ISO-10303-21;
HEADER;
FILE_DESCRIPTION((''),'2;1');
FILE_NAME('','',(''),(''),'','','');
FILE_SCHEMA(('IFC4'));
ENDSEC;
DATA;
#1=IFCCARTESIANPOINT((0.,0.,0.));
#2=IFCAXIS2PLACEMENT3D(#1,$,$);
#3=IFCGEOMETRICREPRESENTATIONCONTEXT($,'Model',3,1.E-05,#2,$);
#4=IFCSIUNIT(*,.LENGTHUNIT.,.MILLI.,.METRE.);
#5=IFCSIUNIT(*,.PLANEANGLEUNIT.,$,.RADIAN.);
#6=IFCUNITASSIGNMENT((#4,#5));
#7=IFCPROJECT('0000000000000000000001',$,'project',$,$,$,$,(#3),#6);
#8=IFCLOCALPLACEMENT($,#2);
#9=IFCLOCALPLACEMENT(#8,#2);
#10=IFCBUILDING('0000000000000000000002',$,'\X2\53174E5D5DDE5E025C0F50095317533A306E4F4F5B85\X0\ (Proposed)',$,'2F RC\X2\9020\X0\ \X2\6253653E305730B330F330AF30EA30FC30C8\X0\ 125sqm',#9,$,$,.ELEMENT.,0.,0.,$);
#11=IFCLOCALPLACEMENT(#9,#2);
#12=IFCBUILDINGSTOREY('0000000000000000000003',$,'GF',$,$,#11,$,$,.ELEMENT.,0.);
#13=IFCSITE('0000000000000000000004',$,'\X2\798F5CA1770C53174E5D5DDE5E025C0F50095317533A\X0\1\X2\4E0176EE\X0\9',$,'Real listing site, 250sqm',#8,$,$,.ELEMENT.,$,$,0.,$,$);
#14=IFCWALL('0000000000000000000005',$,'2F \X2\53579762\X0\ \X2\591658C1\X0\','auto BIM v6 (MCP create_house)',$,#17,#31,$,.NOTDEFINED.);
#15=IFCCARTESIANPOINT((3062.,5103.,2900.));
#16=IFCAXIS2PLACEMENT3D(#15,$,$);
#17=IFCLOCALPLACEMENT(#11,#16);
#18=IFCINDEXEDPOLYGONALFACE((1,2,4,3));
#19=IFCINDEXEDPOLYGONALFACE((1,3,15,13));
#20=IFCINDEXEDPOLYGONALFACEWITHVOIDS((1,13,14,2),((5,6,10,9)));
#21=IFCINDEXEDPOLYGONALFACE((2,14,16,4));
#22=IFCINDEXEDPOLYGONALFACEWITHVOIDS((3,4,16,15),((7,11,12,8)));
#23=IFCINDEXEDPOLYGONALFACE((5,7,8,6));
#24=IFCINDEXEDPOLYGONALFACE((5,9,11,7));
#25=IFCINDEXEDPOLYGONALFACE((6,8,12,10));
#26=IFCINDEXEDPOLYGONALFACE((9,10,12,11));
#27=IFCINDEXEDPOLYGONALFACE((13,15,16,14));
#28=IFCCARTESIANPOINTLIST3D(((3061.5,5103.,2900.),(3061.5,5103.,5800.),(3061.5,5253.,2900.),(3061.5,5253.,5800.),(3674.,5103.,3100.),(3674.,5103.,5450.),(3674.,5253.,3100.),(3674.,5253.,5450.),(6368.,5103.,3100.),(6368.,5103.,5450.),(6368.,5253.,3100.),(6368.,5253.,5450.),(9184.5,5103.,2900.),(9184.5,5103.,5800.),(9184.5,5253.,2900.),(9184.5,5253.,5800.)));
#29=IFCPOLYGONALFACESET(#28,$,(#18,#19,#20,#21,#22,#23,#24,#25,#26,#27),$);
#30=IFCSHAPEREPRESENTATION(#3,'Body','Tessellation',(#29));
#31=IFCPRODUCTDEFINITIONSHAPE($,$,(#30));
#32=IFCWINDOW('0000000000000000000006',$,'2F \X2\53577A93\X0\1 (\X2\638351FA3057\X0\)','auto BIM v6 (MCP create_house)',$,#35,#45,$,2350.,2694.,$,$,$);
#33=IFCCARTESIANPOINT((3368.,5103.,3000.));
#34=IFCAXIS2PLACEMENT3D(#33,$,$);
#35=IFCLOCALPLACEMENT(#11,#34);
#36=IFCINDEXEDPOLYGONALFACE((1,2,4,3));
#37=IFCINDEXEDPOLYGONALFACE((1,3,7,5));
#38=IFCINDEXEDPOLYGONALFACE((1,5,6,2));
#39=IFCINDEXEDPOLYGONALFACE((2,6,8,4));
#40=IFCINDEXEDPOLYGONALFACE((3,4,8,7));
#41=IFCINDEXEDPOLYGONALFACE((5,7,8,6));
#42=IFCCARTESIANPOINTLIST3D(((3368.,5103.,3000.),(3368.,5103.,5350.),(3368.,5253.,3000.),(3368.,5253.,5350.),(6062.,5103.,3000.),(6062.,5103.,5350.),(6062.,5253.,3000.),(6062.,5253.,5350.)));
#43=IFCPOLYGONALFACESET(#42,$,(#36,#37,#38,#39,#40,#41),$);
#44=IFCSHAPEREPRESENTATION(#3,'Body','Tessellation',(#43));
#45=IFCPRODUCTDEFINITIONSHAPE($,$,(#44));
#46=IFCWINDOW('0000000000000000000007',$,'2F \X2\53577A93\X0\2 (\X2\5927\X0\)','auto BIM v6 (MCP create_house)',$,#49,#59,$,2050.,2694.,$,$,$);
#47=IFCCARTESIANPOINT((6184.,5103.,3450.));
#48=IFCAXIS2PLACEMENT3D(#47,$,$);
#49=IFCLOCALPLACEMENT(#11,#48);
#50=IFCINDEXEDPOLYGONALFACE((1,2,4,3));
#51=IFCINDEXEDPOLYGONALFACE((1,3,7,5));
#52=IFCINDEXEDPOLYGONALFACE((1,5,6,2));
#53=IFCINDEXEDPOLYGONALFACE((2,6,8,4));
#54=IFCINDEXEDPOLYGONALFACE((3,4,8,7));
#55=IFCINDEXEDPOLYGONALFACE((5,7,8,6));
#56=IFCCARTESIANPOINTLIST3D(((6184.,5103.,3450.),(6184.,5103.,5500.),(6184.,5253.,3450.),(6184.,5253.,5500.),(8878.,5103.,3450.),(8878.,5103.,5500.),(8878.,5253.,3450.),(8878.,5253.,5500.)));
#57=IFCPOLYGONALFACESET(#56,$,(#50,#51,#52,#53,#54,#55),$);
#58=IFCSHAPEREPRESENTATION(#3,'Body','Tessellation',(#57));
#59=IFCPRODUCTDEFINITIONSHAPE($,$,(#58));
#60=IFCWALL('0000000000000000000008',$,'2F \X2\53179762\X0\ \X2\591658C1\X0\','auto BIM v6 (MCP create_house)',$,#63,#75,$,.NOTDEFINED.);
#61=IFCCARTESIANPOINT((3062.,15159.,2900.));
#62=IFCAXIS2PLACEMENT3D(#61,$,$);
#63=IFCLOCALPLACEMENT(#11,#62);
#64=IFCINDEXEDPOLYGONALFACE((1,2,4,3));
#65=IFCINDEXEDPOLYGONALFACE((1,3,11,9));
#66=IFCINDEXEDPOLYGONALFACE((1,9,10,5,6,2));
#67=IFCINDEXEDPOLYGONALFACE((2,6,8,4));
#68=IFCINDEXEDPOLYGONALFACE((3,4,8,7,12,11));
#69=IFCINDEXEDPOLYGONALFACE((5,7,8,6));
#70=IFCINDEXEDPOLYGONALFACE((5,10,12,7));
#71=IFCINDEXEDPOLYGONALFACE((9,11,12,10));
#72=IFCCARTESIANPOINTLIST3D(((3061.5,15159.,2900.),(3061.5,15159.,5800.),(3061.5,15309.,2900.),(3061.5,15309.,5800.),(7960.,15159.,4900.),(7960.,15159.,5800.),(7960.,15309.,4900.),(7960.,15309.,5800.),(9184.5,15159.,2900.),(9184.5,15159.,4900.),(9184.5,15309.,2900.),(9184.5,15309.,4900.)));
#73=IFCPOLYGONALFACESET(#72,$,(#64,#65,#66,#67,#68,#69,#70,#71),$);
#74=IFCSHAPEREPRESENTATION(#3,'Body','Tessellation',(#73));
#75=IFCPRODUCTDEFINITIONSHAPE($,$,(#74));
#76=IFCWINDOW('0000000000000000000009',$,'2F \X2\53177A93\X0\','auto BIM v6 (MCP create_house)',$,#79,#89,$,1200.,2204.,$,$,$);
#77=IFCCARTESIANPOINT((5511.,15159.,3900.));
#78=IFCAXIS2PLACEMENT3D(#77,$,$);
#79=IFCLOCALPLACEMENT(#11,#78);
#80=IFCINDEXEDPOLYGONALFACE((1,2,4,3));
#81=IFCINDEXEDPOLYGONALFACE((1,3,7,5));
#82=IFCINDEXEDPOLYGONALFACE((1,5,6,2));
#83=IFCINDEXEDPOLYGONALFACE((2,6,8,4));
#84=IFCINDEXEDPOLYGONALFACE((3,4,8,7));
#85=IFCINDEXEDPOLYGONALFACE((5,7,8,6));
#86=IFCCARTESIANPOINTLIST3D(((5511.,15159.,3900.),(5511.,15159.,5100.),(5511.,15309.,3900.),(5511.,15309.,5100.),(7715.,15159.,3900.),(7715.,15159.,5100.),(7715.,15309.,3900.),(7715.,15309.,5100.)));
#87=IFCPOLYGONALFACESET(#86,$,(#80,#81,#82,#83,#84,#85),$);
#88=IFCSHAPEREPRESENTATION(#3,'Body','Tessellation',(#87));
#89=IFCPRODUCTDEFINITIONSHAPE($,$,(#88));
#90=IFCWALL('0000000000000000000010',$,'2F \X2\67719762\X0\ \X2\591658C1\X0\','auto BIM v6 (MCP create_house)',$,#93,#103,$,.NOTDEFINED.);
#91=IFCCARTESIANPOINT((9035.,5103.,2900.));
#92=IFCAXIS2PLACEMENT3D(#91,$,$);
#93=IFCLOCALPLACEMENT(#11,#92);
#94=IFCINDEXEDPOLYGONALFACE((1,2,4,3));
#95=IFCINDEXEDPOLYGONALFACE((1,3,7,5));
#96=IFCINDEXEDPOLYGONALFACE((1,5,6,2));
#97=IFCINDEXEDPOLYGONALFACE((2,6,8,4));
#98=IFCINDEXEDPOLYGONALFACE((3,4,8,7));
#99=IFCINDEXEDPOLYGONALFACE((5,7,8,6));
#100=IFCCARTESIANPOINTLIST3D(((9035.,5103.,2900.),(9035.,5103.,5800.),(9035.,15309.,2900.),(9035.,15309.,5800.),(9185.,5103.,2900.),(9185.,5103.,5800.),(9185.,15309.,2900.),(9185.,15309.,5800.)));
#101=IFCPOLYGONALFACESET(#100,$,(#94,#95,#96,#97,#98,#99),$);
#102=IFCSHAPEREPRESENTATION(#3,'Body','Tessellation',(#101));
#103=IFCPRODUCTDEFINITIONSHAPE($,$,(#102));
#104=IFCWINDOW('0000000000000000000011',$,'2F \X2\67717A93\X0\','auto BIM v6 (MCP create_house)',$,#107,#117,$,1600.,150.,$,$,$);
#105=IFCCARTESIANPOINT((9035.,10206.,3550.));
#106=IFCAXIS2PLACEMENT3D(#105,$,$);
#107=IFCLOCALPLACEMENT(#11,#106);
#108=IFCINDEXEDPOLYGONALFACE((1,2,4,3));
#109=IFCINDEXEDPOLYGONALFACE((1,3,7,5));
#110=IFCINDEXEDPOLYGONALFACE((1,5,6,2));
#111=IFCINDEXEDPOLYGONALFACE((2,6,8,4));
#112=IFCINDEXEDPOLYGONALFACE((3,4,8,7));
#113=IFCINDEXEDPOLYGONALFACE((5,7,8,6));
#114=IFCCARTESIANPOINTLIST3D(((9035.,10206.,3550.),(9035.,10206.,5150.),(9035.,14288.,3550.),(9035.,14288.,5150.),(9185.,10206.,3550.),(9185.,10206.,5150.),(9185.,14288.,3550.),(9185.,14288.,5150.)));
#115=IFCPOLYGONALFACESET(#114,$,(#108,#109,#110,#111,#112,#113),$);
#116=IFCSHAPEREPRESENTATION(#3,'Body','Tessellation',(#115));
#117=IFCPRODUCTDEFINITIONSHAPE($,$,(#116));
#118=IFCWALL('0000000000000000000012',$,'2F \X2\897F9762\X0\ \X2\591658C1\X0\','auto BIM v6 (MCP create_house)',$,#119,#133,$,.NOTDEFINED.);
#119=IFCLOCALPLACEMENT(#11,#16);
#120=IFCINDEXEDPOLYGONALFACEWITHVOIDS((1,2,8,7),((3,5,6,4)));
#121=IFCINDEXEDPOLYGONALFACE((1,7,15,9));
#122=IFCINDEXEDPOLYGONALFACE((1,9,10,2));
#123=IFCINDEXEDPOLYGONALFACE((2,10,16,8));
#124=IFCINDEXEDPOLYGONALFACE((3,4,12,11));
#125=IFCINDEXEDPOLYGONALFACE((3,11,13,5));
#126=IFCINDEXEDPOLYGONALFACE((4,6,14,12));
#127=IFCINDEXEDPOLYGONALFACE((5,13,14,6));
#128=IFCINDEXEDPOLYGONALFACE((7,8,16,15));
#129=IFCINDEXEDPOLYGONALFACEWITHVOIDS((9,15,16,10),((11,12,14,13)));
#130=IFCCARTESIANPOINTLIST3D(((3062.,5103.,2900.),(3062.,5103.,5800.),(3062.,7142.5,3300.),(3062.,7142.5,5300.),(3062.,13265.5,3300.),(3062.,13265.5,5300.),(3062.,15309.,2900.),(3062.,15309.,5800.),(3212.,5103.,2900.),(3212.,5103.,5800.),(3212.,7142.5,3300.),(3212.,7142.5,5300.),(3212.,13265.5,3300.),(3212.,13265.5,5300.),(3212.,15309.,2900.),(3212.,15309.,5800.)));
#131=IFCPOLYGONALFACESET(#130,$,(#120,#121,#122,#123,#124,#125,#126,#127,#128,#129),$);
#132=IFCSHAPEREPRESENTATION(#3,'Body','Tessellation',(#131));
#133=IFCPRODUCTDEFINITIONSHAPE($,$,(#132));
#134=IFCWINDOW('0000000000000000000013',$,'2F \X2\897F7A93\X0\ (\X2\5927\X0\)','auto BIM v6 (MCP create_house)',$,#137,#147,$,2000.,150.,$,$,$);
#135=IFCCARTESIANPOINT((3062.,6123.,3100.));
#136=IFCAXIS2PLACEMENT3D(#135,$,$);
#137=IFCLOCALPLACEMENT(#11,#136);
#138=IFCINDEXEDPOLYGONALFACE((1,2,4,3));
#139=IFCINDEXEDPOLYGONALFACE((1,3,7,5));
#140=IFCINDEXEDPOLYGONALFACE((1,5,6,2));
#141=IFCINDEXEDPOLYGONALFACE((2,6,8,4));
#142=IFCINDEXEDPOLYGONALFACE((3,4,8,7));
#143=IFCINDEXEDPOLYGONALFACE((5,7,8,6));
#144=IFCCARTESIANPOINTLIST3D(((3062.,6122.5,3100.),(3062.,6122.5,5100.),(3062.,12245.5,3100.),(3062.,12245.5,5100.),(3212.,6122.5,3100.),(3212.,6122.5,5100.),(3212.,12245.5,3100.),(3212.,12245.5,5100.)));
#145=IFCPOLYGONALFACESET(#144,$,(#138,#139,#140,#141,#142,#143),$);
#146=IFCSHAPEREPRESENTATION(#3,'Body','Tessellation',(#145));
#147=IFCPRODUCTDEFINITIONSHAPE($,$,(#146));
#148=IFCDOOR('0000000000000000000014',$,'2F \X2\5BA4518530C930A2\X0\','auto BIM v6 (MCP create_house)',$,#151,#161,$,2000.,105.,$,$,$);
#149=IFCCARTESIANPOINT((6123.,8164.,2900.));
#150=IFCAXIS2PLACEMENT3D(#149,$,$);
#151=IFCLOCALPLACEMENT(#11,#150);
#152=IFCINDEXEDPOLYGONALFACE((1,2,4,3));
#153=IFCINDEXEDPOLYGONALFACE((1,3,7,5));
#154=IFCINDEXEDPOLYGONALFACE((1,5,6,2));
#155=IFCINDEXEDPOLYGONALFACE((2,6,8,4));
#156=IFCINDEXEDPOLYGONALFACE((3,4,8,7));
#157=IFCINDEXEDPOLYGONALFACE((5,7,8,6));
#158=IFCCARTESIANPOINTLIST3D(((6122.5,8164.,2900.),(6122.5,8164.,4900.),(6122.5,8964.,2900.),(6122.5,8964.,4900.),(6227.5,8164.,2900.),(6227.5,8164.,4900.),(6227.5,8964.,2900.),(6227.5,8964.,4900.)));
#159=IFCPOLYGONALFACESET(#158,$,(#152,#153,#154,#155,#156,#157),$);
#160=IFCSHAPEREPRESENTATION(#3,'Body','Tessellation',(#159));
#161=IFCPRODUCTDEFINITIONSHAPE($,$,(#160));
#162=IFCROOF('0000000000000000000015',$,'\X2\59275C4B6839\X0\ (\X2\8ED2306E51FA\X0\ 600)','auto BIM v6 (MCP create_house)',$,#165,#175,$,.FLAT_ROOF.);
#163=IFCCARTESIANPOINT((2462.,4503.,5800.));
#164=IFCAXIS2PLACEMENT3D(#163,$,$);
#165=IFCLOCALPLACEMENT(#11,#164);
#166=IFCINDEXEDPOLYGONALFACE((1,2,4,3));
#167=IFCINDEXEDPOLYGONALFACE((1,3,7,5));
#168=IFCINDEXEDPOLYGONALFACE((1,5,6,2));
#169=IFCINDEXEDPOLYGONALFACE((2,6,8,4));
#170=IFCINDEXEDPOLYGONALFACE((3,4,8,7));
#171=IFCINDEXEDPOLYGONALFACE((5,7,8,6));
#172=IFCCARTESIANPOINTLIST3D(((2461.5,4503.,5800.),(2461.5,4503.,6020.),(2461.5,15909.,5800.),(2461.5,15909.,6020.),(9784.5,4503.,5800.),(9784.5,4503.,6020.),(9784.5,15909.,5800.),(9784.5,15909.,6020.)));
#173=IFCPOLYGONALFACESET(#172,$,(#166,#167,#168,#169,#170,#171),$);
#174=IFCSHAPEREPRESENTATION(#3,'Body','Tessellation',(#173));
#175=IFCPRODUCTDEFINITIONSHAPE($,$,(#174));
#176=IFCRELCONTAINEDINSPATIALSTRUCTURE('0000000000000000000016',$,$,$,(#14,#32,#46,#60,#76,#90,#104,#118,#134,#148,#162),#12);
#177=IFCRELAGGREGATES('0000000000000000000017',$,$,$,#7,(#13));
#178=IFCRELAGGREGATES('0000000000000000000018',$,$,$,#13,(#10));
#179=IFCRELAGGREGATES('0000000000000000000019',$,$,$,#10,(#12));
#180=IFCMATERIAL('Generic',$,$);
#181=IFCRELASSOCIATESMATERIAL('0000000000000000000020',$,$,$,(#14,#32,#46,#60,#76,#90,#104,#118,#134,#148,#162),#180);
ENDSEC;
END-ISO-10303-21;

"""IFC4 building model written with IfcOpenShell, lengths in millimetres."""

from ifc_helpers import new_model, si_unit, frame, frame_2d, origin, place, context, project, spatial, rectangle, extrude, material, element, fill, save


model = new_model("IFC4")

# Units and contexts
model_context = context("Model", 3, precision=1e-05, world=origin())
ifc_project = project(units=[si_unit("LENGTHUNIT", "METRE", prefix="MILLI"), si_unit("PLANEANGLEUNIT", "RADIAN")], contexts=[model_context])

# Site, building, storey
site_placement = place(None, origin())
site = spatial("IfcSite", under=ifc_project, at=site_placement, Name="福岡県北九州市小倉北区1丁目9", ObjectType="Real listing site, 250sqm", CompositionType="ELEMENT", RefElevation=0.0)
building_placement = place(site_placement, origin())
building = spatial("IfcBuilding", under=site, at=building_placement, Name="北九州市小倉北区の住宅 (Proposed)", ObjectType="2F RC造 打放しコンクリート 125sqm", CompositionType="ELEMENT", ElevationOfRefHeight=0.0, ElevationOfTerrain=0.0)
storey_placement = place(building_placement, origin())
storey = spatial("IfcBuildingStorey", under=building, at=storey_placement, Name="GF", CompositionType="ELEMENT", Elevation=0.0)

# Shared definitions
ifc_material = material(Name="Generic")

# Wall, openings, windows
wall_1_placement = place(storey_placement, frame((3062.0, 5103.0, 2900.0)))
wall_1 = element("IfcWall", 1, at=wall_1_placement, inside=storey, material=ifc_material, Name="2F 南面 外壁", Description="auto BIM v6 (MCP create_house)", PredefinedType="NOTDEFINED", context=model_context, shape_type="SweptSolid", body=[
    extrude(rectangle(XDim=6123.0, YDim=150.0, at=frame_2d((3061.0, 75.0))), frame((3062.0, 5103.0, 2900.0)), (0.0, 0.0, 1.0), 2900.0),
])
opening_1_placement = place(storey_placement, frame((3368.0, 5103.0, 3000.0)))
opening_1 = element("IfcOpeningElement", 2, at=opening_1_placement, cuts=wall_1, PredefinedType="NOTDEFINED", context=model_context, shape_type="SweptSolid", body=[
    extrude(rectangle(XDim=2694.0, YDim=150.0, at=frame_2d((1347.0, 75.0))), frame((3368.0, 5103.0, 3000.0)), (0.0, 0.0, 1.0), 2350.0),
])
opening_2_placement = place(storey_placement, frame((6184.0, 5103.0, 3450.0)))
opening_2 = element("IfcOpeningElement", 3, at=opening_2_placement, cuts=wall_1, PredefinedType="NOTDEFINED", context=model_context, shape_type="SweptSolid", body=[
    extrude(rectangle(XDim=2694.0, YDim=150.0, at=frame_2d((1347.0, 75.0))), frame((6184.0, 5103.0, 3450.0)), (0.0, 0.0, 1.0), 2050.0),
])
window_1_placement = place(storey_placement, frame((3368.0, 5103.0, 3000.0)))
window_1 = element("IfcWindow", 4, at=window_1_placement, inside=storey, material=ifc_material, Name="2F 南窓1 (掃出し)", Description="auto BIM v6 (MCP create_house)", OverallHeight=2350.0, OverallWidth=2694.0, context=model_context, shape_type="SweptSolid", body=[
    extrude(rectangle(XDim=2694.0, YDim=150.0, at=frame_2d((1347.0, 75.0))), frame((3368.0, 5103.0, 3000.0)), (0.0, 0.0, 1.0), 2350.0),
])
fill(opening_1, window_1)
window_2_placement = place(storey_placement, frame((6184.0, 5103.0, 3450.0)))
window_2 = element("IfcWindow", 5, at=window_2_placement, inside=storey, material=ifc_material, Name="2F 南窓2 (大)", Description="auto BIM v6 (MCP create_house)", OverallHeight=2050.0, OverallWidth=2694.0, context=model_context, shape_type="SweptSolid", body=[
    extrude(rectangle(XDim=2694.0, YDim=150.0, at=frame_2d((1347.0, 75.0))), frame((6184.0, 5103.0, 3450.0)), (0.0, 0.0, 1.0), 2050.0),
])
fill(opening_2, window_2)

# Walls, openings, windows
wall_2_placement = place(storey_placement, frame((3062.0, 15159.0, 2900.0)))
wall_2 = element("IfcWall", 6, at=wall_2_placement, inside=storey, material=ifc_material, Name="2F 北面 外壁", Description="auto BIM v6 (MCP create_house)", PredefinedType="NOTDEFINED", context=model_context, shape_type="SweptSolid", body=[
    extrude(rectangle(XDim=6123.0, YDim=150.0, at=frame_2d((3061.0, 75.0))), frame((3062.0, 15159.0, 2900.0)), (0.0, 0.0, 1.0), 2900.0),
])
opening_3_placement = place(storey_placement, frame((5511.0, 15159.0, 3900.0)))
opening_3 = element("IfcOpeningElement", 7, at=opening_3_placement, cuts=wall_2, PredefinedType="NOTDEFINED", context=model_context, shape_type="SweptSolid", body=[
    extrude(rectangle(XDim=2204.0, YDim=150.0, at=frame_2d((1102.0, 75.0))), frame((5511.0, 15159.0, 3900.0)), (0.0, 0.0, 1.0), 1200.0),
])
window_3_placement = place(storey_placement, frame((5511.0, 15159.0, 3900.0)))
window_3 = element("IfcWindow", 8, at=window_3_placement, inside=storey, material=ifc_material, Name="2F 北窓", Description="auto BIM v6 (MCP create_house)", OverallHeight=1200.0, OverallWidth=2204.0, context=model_context, shape_type="SweptSolid", body=[
    extrude(rectangle(XDim=2204.0, YDim=150.0, at=frame_2d((1102.0, 75.0))), frame((5511.0, 15159.0, 3900.0)), (0.0, 0.0, 1.0), 1200.0),
])
fill(opening_3, window_3)
wall_3_placement = place(storey_placement, frame((9035.0, 5103.0, 2900.0)))
wall_3 = element("IfcWall", 9, at=wall_3_placement, inside=storey, material=ifc_material, Name="2F 東面 外壁", Description="auto BIM v6 (MCP create_house)", PredefinedType="NOTDEFINED", context=model_context, shape_type="SweptSolid", body=[
    extrude(rectangle(XDim=150.0, YDim=10206.0, at=frame_2d((75.0, 5103.0))), frame((9035.0, 5103.0, 2900.0)), (0.0, 0.0, 1.0), 2900.0),
])
opening_4_placement = place(storey_placement, frame((9035.0, 10206.0, 3550.0)))
opening_4 = element("IfcOpeningElement", 10, at=opening_4_placement, cuts=wall_3, PredefinedType="NOTDEFINED", context=model_context, shape_type="SweptSolid", body=[
    extrude(rectangle(XDim=150.0, YDim=4082.0, at=frame_2d((75.0, 2041.0))), frame((9035.0, 10206.0, 3550.0)), (0.0, 0.0, 1.0), 1600.0),
])
window_4_placement = place(storey_placement, frame((9035.0, 10206.0, 3550.0)))
window_4 = element("IfcWindow", 11, at=window_4_placement, inside=storey, material=ifc_material, Name="2F 東窓", Description="auto BIM v6 (MCP create_house)", OverallHeight=1600.0, OverallWidth=150.0, context=model_context, shape_type="SweptSolid", body=[
    extrude(rectangle(XDim=150.0, YDim=4082.0, at=frame_2d((75.0, 2041.0))), frame((9035.0, 10206.0, 3550.0)), (0.0, 0.0, 1.0), 1600.0),
])
fill(opening_4, window_4)
wall_4_placement = place(storey_placement, frame((3062.0, 5103.0, 2900.0)))
wall_4 = element("IfcWall", 12, at=wall_4_placement, inside=storey, material=ifc_material, Name="2F 西面 外壁", Description="auto BIM v6 (MCP create_house)", PredefinedType="NOTDEFINED", context=model_context, shape_type="SweptSolid", body=[
    extrude(rectangle(XDim=150.0, YDim=10206.0, at=frame_2d((75.0, 5103.0))), frame((3062.0, 5103.0, 2900.0)), (0.0, 0.0, 1.0), 2900.0),
])
opening_5_placement = place(storey_placement, frame((3062.0, 6123.0, 3100.0)))
opening_5 = element("IfcOpeningElement", 13, at=opening_5_placement, cuts=wall_4, PredefinedType="NOTDEFINED", context=model_context, shape_type="SweptSolid", body=[
    extrude(rectangle(XDim=150.0, YDim=6123.0, at=frame_2d((75.0, 3061.0))), frame((3062.0, 6123.0, 3100.0)), (0.0, 0.0, 1.0), 2000.0),
])
window_5_placement = place(storey_placement, frame((3062.0, 6123.0, 3100.0)))
window_5 = element("IfcWindow", 14, at=window_5_placement, inside=storey, material=ifc_material, Name="2F 西窓 (大)", Description="auto BIM v6 (MCP create_house)", OverallHeight=2000.0, OverallWidth=150.0, context=model_context, shape_type="SweptSolid", body=[
    extrude(rectangle(XDim=150.0, YDim=6123.0, at=frame_2d((75.0, 3061.0))), frame((3062.0, 6123.0, 3100.0)), (0.0, 0.0, 1.0), 2000.0),
])
fill(opening_5, window_5)

# Door
door_1_placement = place(storey_placement, frame((6123.0, 8164.0, 2900.0)))
element("IfcDoor", 15, at=door_1_placement, inside=storey, material=ifc_material, Name="2F 室内ドア", Description="auto BIM v6 (MCP create_house)", OverallHeight=2000.0, OverallWidth=105.0, context=model_context, shape_type="SweptSolid", body=[
    extrude(rectangle(XDim=105.0, YDim=800.0, at=frame_2d((52.0, 400.0))), frame((6123.0, 8164.0, 2900.0)), (0.0, 0.0, 1.0), 2000.0),
])

# Roof
roof_placement = place(storey_placement, frame((2462.0, 4503.0, 5800.0)))
element("IfcRoof", 16, at=roof_placement, inside=storey, material=ifc_material, Name="大屋根 (軒の出 600)", Description="auto BIM v6 (MCP create_house)", PredefinedType="FLAT_ROOF", context=model_context, shape_type="SweptSolid", body=[
    extrude(rectangle(XDim=7323.0, YDim=11406.0, at=frame_2d((3661.0, 5703.0))), frame((2462.0, 4503.0, 5800.0)), (0.0, 0.0, 1.0), 220.0),
])

save(model, "model.ifc")
